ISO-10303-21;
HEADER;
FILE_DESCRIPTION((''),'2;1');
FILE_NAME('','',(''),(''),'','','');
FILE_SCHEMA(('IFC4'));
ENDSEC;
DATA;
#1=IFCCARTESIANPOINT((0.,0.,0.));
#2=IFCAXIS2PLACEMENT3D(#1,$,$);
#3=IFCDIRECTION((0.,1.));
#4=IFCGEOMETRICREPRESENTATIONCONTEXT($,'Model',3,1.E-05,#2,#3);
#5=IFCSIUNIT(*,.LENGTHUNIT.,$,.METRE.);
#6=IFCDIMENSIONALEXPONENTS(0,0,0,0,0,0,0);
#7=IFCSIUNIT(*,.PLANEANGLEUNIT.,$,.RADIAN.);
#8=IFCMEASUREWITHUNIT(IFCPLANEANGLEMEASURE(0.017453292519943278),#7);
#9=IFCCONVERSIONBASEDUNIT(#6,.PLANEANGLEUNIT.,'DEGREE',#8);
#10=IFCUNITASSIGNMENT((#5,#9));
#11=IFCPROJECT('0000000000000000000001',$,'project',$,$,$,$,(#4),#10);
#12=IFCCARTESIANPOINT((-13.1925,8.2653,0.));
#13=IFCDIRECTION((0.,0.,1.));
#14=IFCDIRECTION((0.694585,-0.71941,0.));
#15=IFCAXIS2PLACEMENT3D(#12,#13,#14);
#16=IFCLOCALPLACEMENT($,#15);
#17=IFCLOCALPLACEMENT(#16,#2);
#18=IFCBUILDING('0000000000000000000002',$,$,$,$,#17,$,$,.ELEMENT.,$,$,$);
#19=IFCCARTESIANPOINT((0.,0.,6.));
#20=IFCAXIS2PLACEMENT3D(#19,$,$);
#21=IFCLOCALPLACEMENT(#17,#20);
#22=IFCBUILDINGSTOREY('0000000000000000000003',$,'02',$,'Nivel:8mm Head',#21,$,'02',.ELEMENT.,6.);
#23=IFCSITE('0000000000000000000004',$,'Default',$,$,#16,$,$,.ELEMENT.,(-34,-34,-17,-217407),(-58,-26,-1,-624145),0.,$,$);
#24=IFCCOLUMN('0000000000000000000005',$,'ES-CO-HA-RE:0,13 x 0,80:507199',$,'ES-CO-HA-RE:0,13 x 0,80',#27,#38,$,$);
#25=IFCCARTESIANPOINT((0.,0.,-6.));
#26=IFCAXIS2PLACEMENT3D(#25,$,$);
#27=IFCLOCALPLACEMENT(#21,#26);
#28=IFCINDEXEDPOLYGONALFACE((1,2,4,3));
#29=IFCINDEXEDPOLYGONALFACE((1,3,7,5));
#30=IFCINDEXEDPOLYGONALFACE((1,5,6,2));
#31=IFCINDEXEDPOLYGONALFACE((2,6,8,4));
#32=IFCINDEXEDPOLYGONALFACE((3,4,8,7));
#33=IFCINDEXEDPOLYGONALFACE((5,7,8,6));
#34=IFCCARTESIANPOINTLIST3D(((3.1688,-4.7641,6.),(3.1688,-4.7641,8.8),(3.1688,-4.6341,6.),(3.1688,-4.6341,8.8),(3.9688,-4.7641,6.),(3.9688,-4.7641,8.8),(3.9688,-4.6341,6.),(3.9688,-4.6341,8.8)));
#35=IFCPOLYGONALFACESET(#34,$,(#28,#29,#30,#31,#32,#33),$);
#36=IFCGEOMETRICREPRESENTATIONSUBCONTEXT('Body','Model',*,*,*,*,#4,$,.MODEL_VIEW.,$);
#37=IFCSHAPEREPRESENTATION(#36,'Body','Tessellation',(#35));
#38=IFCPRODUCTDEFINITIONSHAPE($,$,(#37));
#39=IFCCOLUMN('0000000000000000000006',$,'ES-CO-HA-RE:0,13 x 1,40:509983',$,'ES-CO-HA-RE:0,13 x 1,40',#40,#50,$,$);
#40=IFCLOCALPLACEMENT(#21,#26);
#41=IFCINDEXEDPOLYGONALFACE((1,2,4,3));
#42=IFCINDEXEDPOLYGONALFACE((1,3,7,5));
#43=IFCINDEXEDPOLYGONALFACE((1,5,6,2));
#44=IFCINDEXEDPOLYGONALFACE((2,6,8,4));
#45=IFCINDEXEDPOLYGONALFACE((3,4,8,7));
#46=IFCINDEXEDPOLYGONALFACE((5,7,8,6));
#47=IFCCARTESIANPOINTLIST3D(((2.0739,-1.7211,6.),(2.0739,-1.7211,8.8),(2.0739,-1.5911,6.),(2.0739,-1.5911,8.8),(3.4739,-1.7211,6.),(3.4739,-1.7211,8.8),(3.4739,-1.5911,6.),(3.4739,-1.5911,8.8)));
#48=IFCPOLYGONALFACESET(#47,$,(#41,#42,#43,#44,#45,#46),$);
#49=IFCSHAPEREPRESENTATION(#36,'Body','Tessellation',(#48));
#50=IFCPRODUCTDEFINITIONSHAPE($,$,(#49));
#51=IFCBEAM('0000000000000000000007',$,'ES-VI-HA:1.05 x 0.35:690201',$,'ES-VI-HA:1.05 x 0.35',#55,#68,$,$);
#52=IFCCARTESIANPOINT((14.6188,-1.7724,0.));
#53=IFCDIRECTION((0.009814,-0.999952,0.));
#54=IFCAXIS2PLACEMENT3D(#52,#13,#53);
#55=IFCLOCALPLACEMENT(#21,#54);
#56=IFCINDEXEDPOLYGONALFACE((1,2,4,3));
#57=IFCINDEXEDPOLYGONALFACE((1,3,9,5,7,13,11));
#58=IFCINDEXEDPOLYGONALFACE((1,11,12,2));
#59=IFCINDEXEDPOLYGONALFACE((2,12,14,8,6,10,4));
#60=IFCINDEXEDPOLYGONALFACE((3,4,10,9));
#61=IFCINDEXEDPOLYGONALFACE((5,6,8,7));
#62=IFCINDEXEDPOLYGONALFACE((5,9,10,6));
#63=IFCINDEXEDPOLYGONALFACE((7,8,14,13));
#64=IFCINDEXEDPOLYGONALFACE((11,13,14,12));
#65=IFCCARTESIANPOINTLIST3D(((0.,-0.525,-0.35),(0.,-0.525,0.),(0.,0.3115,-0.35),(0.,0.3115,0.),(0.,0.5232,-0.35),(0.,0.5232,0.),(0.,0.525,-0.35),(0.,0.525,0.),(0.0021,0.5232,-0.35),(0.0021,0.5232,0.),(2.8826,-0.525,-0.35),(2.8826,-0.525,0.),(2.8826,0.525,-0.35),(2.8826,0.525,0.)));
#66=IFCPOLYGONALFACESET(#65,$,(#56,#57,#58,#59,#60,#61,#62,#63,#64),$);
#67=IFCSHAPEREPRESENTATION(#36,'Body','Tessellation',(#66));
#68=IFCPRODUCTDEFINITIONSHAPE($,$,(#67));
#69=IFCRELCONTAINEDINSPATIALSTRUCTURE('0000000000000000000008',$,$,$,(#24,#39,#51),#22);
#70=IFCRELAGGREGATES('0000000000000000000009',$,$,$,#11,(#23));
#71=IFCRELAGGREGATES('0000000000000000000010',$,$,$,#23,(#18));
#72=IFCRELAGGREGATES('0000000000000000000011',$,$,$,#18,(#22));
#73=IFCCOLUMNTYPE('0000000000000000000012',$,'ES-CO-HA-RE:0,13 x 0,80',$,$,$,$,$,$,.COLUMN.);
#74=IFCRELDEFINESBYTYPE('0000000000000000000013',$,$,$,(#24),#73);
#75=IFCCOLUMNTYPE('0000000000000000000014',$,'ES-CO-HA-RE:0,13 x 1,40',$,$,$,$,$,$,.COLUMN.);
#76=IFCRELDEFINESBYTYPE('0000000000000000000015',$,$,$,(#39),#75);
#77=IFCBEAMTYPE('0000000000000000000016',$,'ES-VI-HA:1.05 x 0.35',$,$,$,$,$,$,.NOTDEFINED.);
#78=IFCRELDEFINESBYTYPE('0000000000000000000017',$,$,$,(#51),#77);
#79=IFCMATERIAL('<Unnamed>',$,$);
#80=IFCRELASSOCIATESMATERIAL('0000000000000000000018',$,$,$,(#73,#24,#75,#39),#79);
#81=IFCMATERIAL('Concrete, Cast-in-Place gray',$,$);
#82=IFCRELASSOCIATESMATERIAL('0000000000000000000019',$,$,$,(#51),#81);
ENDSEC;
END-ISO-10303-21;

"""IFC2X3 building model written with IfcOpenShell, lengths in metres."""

from ifc_helpers import new_model, entity, si_unit, converted_unit, direction, frame, frame_2d, origin, place, context, subcontext, project, spatial, polyline, rectangle, extrude, clip, bounded_halfspace, source, transform, mapped, material, type_object, type_shapes, element, save


model = new_model("IFC2X3")

# Units and contexts
model_context = context("Model", 3, precision=1e-05, world=origin(), true_north=direction((0.0, 1.0)))
body_context = subcontext(model_context, "Body", "Model", "MODEL_VIEW")
ifc_project = project(units=[si_unit("LENGTHUNIT", "METRE"), converted_unit("PLANEANGLEUNIT", "DEGREE", entity("IfcPlaneAngleMeasure", 0.017453292519943278), si_unit("PLANEANGLEUNIT", "RADIAN"), dimensions=[0, 0, 0, 0, 0, 0, 0])], contexts=[model_context])

# Site, building, storey
site_placement = place(None, frame((-13.1925, 8.2653, 0.0), z_axis=(0.0, 0.0, 1.0), x_axis=(0.694585, -0.71941, 0.0)))
site = spatial("IfcSite", under=ifc_project, at=site_placement, Name="Default", CompositionType="ELEMENT", RefLatitude=(-34, -34, -17, -217407), RefLongitude=(-58, -26, -1, -624145), RefElevation=0.0)
building_placement = place(site_placement, origin())
building = spatial("IfcBuilding", under=site, at=building_placement, CompositionType="ELEMENT")
storey_placement = place(building_placement, frame((0.0, 0.0, 6.0)))
storey = spatial("IfcBuildingStorey", under=building, at=storey_placement, Name="02", ObjectType="Nivel:8mm Head", LongName="02", CompositionType="ELEMENT", Elevation=6.0)

# Columns
ifc_material_1 = material(Name="<Unnamed>")
column_type_1 = type_object("IfcColumnType", Name="ES-CO-HA-RE:0,13 x 0,80", PredefinedType="COLUMN", material=ifc_material_1)
shared_shape_1 = source(origin(), body_context, "Body", "SweptSolid", [
    extrude(rectangle(XDim=0.8, YDim=0.13, at=frame_2d((0.0, 0.0), x_axis=(1.0, 0.0))), frame((3.5688, -4.6991, 6.0), z_axis=(0.0, 0.0, 1.0), x_axis=(-1.0, 0.0, 0.0)), (0.0, 0.0, 1.0), 2.8),
])
type_shapes(column_type_1, [shared_shape_1])
column_1_placement = place(storey_placement, frame((0.0, 0.0, -6.0)))
element("IfcColumn", 1, at=column_1_placement, inside=storey, type_object=column_type_1, material=ifc_material_1, Name="ES-CO-HA-RE:0,13 x 0,80:507199", ObjectType="ES-CO-HA-RE:0,13 x 0,80", context=body_context, shape_type="MappedRepresentation", body=[
    mapped(shared_shape_1, transform((0.0, 0.0, 0.0), scale=1.0)),
])
column_type_2 = type_object("IfcColumnType", Name="ES-CO-HA-RE:0,13 x 1,40", PredefinedType="COLUMN", material=ifc_material_1)
shared_shape_2 = source(origin(), body_context, "Body", "SweptSolid", [
    extrude(rectangle(XDim=1.4, YDim=0.13, at=frame_2d((0.0, 0.0), x_axis=(1.0, 0.0))), frame((2.7739, -1.6561, 6.0), z_axis=(0.0, 0.0, 1.0), x_axis=(-1.0, 0.0, 0.0)), (0.0, 0.0, 1.0), 2.8),
])
type_shapes(column_type_2, [shared_shape_2])
column_2_placement = place(storey_placement, frame((0.0, 0.0, -6.0)))
element("IfcColumn", 2, at=column_2_placement, inside=storey, type_object=column_type_2, material=ifc_material_1, Name="ES-CO-HA-RE:0,13 x 1,40:509983", ObjectType="ES-CO-HA-RE:0,13 x 1,40", context=body_context, shape_type="MappedRepresentation", body=[
    mapped(shared_shape_2, transform((0.0, 0.0, 0.0), scale=1.0)),
])

# Beam
ifc_material_2 = material(Name="Concrete, Cast-in-Place gray")
beam_type_1 = type_object("IfcBeamType", Name="ES-VI-HA:1.05 x 0.35", PredefinedType="NOTDEFINED")
beam_1_placement = place(storey_placement, frame((14.6188, -1.7724, 0.0), z_axis=(0.0, 0.0, 1.0), x_axis=(0.009814, -0.999952, 0.0)))
element("IfcBeam", 3, at=beam_1_placement, inside=storey, type_object=beam_type_1, material=ifc_material_2, Name="ES-VI-HA:1.05 x 0.35:690201", ObjectType="ES-VI-HA:1.05 x 0.35", context=body_context, shape_type="SweptSolid", body=[
    clip(clip(extrude(rectangle(XDim=0.35, YDim=1.05, at=frame_2d((0.0, 0.0), x_axis=(1.0, 0.0))), frame((0.0, 0.0, -0.175), z_axis=(1.0, 0.0, 0.0), x_axis=(0.0, 0.0, -1.0)), (0.0, 0.0, 1.0), 2.8826), bounded_halfspace(frame((0.0021, 0.5232, 0.0), z_axis=(-0.009814, -0.999952, 0.0), x_axis=(0.0, 0.0, -1.0)), False, frame((0.0, 0.0, -0.175), z_axis=(1.0, 0.0, 0.0), x_axis=(0.0, 0.0, -1.0)), polyline([(0.175, 0.5232), (-0.175, 0.5232), (-0.175, 0.5232), (0.175, 0.5232), (0.175, 0.5232)]))), bounded_halfspace(frame((-0.0082, -0.5268, 0.0), z_axis=(-0.999952, 0.009814, 0.0), x_axis=(0.0, 0.0, -1.0)), False, frame((0.0, 0.0, -0.175), z_axis=(1.0, 0.0, 0.0), x_axis=(0.0, 0.0, -1.0)), polyline([(-0.175, 0.5232), (0.175, 0.5232), (0.175, 0.3115), (-0.175, 0.3115), (-0.175, 0.5232)]))),
])

save(model, "model.ifc")
